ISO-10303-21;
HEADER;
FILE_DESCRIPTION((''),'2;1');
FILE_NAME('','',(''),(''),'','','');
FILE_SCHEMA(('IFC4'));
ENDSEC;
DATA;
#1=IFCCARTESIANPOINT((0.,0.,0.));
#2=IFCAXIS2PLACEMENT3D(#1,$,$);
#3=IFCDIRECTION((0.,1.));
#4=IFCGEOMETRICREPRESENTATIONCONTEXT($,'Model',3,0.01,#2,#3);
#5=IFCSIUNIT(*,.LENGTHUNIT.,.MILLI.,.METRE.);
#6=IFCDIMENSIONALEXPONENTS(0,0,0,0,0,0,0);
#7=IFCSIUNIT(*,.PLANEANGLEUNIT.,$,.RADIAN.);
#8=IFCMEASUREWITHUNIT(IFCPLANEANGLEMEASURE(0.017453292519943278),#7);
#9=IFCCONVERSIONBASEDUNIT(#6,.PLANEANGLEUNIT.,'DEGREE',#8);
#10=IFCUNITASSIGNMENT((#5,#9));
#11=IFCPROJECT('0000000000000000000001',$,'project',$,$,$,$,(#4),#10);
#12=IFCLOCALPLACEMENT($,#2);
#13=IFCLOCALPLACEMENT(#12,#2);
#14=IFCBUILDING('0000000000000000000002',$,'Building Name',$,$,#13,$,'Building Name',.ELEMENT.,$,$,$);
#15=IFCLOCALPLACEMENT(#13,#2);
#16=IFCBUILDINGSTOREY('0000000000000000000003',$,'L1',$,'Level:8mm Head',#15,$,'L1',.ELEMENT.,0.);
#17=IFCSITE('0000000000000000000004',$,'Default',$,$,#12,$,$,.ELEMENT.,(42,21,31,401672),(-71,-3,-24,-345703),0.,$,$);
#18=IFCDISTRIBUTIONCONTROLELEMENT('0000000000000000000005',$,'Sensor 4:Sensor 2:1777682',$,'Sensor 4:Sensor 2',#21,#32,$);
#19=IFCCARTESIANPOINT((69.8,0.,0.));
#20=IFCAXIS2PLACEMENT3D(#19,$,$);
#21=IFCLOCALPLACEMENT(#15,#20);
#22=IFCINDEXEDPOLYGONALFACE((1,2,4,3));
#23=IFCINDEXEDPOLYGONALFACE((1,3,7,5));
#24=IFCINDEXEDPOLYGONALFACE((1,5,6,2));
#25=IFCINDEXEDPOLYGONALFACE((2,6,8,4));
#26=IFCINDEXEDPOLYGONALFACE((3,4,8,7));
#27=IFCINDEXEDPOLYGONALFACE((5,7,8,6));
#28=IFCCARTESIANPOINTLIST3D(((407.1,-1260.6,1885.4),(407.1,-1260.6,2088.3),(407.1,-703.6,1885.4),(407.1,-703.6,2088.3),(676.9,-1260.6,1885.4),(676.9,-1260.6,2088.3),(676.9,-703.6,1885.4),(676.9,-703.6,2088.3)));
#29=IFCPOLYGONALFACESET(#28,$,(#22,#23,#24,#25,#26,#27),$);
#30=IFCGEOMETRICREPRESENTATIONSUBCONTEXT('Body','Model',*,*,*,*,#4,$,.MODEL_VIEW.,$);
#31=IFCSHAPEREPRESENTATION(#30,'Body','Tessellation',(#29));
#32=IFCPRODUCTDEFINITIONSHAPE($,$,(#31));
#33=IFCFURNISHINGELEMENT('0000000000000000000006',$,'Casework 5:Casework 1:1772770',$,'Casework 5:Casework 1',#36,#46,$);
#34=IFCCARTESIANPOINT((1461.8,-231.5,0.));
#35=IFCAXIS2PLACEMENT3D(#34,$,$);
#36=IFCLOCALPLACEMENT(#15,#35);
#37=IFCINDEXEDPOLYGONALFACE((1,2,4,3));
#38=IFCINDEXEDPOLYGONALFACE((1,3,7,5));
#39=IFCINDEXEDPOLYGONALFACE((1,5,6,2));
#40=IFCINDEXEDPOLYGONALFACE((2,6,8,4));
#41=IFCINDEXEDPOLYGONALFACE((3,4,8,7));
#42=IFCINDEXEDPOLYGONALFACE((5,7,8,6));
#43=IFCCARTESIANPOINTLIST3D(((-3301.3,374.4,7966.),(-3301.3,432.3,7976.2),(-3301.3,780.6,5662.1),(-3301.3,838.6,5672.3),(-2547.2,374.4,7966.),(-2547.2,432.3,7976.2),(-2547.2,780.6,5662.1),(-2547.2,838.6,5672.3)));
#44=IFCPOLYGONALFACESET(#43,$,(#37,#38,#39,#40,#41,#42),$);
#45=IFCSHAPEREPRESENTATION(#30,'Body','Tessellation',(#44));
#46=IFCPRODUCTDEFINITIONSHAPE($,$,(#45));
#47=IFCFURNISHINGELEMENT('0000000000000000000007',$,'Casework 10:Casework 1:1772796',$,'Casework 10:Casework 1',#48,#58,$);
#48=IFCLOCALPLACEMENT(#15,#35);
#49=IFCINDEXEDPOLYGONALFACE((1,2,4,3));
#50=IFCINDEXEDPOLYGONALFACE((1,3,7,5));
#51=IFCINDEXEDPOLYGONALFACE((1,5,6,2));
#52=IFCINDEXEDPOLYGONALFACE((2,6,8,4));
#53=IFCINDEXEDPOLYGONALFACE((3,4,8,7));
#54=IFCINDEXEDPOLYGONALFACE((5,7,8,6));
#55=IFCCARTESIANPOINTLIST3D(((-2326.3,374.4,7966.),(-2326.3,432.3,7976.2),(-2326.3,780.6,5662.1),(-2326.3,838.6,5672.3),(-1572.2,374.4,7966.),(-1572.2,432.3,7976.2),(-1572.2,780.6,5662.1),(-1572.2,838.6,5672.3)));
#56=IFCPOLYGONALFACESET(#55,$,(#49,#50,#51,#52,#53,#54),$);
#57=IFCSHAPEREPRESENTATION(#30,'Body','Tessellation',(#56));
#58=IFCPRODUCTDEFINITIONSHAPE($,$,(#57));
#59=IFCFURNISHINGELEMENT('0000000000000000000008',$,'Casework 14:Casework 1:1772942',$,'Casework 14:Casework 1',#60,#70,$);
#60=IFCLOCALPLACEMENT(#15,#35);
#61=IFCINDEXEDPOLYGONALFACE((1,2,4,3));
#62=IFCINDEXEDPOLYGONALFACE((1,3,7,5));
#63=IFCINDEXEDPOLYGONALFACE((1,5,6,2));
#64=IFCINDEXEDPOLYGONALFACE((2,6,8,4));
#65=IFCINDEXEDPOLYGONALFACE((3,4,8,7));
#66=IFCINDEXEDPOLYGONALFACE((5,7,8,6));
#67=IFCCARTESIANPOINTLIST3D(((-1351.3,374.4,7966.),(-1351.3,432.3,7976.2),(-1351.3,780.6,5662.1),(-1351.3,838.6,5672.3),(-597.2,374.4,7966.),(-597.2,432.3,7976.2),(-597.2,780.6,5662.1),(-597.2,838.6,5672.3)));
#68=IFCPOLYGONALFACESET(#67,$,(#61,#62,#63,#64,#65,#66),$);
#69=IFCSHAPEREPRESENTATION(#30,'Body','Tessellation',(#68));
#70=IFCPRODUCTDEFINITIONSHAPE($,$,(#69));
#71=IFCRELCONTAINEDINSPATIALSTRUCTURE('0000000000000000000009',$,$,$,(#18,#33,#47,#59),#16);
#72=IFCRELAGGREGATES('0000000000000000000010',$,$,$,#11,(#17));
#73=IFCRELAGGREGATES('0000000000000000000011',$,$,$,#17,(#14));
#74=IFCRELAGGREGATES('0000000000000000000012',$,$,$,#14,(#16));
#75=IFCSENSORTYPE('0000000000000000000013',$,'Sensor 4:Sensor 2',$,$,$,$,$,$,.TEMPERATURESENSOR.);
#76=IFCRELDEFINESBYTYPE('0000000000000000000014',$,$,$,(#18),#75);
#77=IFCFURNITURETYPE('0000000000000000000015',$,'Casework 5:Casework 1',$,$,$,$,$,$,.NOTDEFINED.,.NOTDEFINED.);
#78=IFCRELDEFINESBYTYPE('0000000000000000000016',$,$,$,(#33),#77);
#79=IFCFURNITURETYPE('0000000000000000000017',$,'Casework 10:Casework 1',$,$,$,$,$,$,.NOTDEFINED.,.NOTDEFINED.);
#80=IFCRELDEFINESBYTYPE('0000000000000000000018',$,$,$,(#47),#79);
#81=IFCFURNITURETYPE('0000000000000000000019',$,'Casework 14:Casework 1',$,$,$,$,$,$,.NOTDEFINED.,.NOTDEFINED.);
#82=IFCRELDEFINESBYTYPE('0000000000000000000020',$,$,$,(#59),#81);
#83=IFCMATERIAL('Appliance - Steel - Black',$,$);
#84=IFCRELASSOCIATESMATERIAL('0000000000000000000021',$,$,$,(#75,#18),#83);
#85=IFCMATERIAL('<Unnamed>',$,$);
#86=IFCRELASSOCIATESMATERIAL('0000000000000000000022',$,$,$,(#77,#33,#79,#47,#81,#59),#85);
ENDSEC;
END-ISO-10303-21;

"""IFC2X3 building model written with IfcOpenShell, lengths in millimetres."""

from ifc_helpers import new_model, entity, si_unit, converted_unit, direction, frame, frame_2d, origin, place, context, subcontext, project, spatial, rectangle, extrude, source, transform, mapped, material, type_object, type_shapes, element, save


model = new_model("IFC2X3")

# Units and contexts
model_context = context("Model", 3, precision=0.01, world=origin(), true_north=direction((0.0, 1.0)))
body_context = subcontext(model_context, "Body", "Model", "MODEL_VIEW")
ifc_project = project(units=[si_unit("LENGTHUNIT", "METRE", prefix="MILLI"), converted_unit("PLANEANGLEUNIT", "DEGREE", entity("IfcPlaneAngleMeasure", 0.017453292519943278), si_unit("PLANEANGLEUNIT", "RADIAN"), dimensions=[0, 0, 0, 0, 0, 0, 0])], contexts=[model_context])

# Site, building, storey
site_placement = place(None, origin())
site = spatial("IfcSite", under=ifc_project, at=site_placement, Name="Default", CompositionType="ELEMENT", RefLatitude=(42, 21, 31, 401672), RefLongitude=(-71, -3, -24, -345703), RefElevation=0.0)
building_placement = place(site_placement, origin())
building = spatial("IfcBuilding", under=site, at=building_placement, Name="Building Name", LongName="Building Name", CompositionType="ELEMENT")
storey_placement = place(building_placement, origin())
storey = spatial("IfcBuildingStorey", under=building, at=storey_placement, Name="L1", ObjectType="Level:8mm Head", LongName="L1", CompositionType="ELEMENT", Elevation=0.0)

# Shared definitions
ifc_material_1 = material(Name="<Unnamed>")

# Distribution control element
ifc_material_2 = material(Name="Appliance - Steel - Black")
sensor_type_1 = type_object("IfcSensorType", Name="Sensor 4:Sensor 2", PredefinedType="TEMPERATURESENSOR", material=ifc_material_2)
shared_shape_1 = source(origin(), body_context, "Body", "SweptSolid", [
    extrude(rectangle(XDim=557.0, YDim=269.8, at=frame_2d((0.0, 0.0), x_axis=(1.0, 0.0))), frame((542.0, -982.1, 1885.4), z_axis=(0.0, 0.0, 1.0), x_axis=(0.0, -1.0, 0.0)), (0.0, 0.0, 1.0), 202.9),
])
type_shapes(sensor_type_1, [shared_shape_1])
distribution_control_element_1_placement = place(storey_placement, frame((69.8, 0.0, 0.0)))
element("IfcDistributionControlElement", 1, at=distribution_control_element_1_placement, inside=storey, type_object=sensor_type_1, material=ifc_material_2, Name="Sensor 4:Sensor 2:1777682", ObjectType="Sensor 4:Sensor 2", context=body_context, shape_type="MappedRepresentation", body=[
    mapped(shared_shape_1, transform((0.0, 0.0, 0.0), scale=1.0)),
])

# Furnishing elements
furniture_type_1 = type_object("IfcFurnitureType", Name="Casework 5:Casework 1", AssemblyPlace="NOTDEFINED", material=ifc_material_1)
shared_shape_2 = source(origin(), body_context, "Body", "SweptSolid", [
    extrude(rectangle(XDim=58.9, YDim=754.1, at=frame_2d((0.0, 0.0), x_axis=(1.0, 0.0))), frame((-2924.3, 809.6, 5667.2), z_axis=(0.0, -0.173648, 0.984808), x_axis=(0.0, -0.984808, -0.173648)), (0.0, 0.0, 1.0), 2339.4),
])
type_shapes(furniture_type_1, [shared_shape_2])
furnishing_1_placement = place(storey_placement, frame((1461.8, -231.5, 0.0)))
element("IfcFurnishingElement", 2, at=furnishing_1_placement, inside=storey, type_object=furniture_type_1, material=ifc_material_1, Name="Casework 5:Casework 1:1772770", ObjectType="Casework 5:Casework 1", context=body_context, shape_type="MappedRepresentation", body=[
    mapped(shared_shape_2, transform((0.0, 0.0, 0.0), scale=1.0)),
])
furniture_type_2 = type_object("IfcFurnitureType", Name="Casework 10:Casework 1", AssemblyPlace="NOTDEFINED", material=ifc_material_1)
shared_shape_3 = source(origin(), body_context, "Body", "SweptSolid", [
    extrude(rectangle(XDim=58.9, YDim=754.1, at=frame_2d((0.0, 0.0), x_axis=(1.0, 0.0))), frame((-1949.3, 809.6, 5667.2), z_axis=(0.0, -0.173648, 0.984808), x_axis=(0.0, -0.984808, -0.173648)), (0.0, 0.0, 1.0), 2339.4),
])
type_shapes(furniture_type_2, [shared_shape_3])
furnishing_2_placement = place(storey_placement, frame((1461.8, -231.5, 0.0)))
element("IfcFurnishingElement", 3, at=furnishing_2_placement, inside=storey, type_object=furniture_type_2, material=ifc_material_1, Name="Casework 10:Casework 1:1772796", ObjectType="Casework 10:Casework 1", context=body_context, shape_type="MappedRepresentation", body=[
    mapped(shared_shape_3, transform((0.0, 0.0, 0.0), scale=1.0)),
])
furniture_type_3 = type_object("IfcFurnitureType", Name="Casework 14:Casework 1", AssemblyPlace="NOTDEFINED", material=ifc_material_1)
shared_shape_4 = source(origin(), body_context, "Body", "SweptSolid", [
    extrude(rectangle(XDim=58.9, YDim=754.1, at=frame_2d((0.0, 0.0), x_axis=(1.0, 0.0))), frame((-974.3, 809.6, 5667.2), z_axis=(0.0, -0.173648, 0.984808), x_axis=(0.0, -0.984808, -0.173648)), (0.0, 0.0, 1.0), 2339.4),
])
type_shapes(furniture_type_3, [shared_shape_4])
furnishing_3_placement = place(storey_placement, frame((1461.8, -231.5, 0.0)))
element("IfcFurnishingElement", 4, at=furnishing_3_placement, inside=storey, type_object=furniture_type_3, material=ifc_material_1, Name="Casework 14:Casework 1:1772942", ObjectType="Casework 14:Casework 1", context=body_context, shape_type="MappedRepresentation", body=[
    mapped(shared_shape_4, transform((0.0, 0.0, 0.0), scale=1.0)),
])

save(model, "model.ifc")
